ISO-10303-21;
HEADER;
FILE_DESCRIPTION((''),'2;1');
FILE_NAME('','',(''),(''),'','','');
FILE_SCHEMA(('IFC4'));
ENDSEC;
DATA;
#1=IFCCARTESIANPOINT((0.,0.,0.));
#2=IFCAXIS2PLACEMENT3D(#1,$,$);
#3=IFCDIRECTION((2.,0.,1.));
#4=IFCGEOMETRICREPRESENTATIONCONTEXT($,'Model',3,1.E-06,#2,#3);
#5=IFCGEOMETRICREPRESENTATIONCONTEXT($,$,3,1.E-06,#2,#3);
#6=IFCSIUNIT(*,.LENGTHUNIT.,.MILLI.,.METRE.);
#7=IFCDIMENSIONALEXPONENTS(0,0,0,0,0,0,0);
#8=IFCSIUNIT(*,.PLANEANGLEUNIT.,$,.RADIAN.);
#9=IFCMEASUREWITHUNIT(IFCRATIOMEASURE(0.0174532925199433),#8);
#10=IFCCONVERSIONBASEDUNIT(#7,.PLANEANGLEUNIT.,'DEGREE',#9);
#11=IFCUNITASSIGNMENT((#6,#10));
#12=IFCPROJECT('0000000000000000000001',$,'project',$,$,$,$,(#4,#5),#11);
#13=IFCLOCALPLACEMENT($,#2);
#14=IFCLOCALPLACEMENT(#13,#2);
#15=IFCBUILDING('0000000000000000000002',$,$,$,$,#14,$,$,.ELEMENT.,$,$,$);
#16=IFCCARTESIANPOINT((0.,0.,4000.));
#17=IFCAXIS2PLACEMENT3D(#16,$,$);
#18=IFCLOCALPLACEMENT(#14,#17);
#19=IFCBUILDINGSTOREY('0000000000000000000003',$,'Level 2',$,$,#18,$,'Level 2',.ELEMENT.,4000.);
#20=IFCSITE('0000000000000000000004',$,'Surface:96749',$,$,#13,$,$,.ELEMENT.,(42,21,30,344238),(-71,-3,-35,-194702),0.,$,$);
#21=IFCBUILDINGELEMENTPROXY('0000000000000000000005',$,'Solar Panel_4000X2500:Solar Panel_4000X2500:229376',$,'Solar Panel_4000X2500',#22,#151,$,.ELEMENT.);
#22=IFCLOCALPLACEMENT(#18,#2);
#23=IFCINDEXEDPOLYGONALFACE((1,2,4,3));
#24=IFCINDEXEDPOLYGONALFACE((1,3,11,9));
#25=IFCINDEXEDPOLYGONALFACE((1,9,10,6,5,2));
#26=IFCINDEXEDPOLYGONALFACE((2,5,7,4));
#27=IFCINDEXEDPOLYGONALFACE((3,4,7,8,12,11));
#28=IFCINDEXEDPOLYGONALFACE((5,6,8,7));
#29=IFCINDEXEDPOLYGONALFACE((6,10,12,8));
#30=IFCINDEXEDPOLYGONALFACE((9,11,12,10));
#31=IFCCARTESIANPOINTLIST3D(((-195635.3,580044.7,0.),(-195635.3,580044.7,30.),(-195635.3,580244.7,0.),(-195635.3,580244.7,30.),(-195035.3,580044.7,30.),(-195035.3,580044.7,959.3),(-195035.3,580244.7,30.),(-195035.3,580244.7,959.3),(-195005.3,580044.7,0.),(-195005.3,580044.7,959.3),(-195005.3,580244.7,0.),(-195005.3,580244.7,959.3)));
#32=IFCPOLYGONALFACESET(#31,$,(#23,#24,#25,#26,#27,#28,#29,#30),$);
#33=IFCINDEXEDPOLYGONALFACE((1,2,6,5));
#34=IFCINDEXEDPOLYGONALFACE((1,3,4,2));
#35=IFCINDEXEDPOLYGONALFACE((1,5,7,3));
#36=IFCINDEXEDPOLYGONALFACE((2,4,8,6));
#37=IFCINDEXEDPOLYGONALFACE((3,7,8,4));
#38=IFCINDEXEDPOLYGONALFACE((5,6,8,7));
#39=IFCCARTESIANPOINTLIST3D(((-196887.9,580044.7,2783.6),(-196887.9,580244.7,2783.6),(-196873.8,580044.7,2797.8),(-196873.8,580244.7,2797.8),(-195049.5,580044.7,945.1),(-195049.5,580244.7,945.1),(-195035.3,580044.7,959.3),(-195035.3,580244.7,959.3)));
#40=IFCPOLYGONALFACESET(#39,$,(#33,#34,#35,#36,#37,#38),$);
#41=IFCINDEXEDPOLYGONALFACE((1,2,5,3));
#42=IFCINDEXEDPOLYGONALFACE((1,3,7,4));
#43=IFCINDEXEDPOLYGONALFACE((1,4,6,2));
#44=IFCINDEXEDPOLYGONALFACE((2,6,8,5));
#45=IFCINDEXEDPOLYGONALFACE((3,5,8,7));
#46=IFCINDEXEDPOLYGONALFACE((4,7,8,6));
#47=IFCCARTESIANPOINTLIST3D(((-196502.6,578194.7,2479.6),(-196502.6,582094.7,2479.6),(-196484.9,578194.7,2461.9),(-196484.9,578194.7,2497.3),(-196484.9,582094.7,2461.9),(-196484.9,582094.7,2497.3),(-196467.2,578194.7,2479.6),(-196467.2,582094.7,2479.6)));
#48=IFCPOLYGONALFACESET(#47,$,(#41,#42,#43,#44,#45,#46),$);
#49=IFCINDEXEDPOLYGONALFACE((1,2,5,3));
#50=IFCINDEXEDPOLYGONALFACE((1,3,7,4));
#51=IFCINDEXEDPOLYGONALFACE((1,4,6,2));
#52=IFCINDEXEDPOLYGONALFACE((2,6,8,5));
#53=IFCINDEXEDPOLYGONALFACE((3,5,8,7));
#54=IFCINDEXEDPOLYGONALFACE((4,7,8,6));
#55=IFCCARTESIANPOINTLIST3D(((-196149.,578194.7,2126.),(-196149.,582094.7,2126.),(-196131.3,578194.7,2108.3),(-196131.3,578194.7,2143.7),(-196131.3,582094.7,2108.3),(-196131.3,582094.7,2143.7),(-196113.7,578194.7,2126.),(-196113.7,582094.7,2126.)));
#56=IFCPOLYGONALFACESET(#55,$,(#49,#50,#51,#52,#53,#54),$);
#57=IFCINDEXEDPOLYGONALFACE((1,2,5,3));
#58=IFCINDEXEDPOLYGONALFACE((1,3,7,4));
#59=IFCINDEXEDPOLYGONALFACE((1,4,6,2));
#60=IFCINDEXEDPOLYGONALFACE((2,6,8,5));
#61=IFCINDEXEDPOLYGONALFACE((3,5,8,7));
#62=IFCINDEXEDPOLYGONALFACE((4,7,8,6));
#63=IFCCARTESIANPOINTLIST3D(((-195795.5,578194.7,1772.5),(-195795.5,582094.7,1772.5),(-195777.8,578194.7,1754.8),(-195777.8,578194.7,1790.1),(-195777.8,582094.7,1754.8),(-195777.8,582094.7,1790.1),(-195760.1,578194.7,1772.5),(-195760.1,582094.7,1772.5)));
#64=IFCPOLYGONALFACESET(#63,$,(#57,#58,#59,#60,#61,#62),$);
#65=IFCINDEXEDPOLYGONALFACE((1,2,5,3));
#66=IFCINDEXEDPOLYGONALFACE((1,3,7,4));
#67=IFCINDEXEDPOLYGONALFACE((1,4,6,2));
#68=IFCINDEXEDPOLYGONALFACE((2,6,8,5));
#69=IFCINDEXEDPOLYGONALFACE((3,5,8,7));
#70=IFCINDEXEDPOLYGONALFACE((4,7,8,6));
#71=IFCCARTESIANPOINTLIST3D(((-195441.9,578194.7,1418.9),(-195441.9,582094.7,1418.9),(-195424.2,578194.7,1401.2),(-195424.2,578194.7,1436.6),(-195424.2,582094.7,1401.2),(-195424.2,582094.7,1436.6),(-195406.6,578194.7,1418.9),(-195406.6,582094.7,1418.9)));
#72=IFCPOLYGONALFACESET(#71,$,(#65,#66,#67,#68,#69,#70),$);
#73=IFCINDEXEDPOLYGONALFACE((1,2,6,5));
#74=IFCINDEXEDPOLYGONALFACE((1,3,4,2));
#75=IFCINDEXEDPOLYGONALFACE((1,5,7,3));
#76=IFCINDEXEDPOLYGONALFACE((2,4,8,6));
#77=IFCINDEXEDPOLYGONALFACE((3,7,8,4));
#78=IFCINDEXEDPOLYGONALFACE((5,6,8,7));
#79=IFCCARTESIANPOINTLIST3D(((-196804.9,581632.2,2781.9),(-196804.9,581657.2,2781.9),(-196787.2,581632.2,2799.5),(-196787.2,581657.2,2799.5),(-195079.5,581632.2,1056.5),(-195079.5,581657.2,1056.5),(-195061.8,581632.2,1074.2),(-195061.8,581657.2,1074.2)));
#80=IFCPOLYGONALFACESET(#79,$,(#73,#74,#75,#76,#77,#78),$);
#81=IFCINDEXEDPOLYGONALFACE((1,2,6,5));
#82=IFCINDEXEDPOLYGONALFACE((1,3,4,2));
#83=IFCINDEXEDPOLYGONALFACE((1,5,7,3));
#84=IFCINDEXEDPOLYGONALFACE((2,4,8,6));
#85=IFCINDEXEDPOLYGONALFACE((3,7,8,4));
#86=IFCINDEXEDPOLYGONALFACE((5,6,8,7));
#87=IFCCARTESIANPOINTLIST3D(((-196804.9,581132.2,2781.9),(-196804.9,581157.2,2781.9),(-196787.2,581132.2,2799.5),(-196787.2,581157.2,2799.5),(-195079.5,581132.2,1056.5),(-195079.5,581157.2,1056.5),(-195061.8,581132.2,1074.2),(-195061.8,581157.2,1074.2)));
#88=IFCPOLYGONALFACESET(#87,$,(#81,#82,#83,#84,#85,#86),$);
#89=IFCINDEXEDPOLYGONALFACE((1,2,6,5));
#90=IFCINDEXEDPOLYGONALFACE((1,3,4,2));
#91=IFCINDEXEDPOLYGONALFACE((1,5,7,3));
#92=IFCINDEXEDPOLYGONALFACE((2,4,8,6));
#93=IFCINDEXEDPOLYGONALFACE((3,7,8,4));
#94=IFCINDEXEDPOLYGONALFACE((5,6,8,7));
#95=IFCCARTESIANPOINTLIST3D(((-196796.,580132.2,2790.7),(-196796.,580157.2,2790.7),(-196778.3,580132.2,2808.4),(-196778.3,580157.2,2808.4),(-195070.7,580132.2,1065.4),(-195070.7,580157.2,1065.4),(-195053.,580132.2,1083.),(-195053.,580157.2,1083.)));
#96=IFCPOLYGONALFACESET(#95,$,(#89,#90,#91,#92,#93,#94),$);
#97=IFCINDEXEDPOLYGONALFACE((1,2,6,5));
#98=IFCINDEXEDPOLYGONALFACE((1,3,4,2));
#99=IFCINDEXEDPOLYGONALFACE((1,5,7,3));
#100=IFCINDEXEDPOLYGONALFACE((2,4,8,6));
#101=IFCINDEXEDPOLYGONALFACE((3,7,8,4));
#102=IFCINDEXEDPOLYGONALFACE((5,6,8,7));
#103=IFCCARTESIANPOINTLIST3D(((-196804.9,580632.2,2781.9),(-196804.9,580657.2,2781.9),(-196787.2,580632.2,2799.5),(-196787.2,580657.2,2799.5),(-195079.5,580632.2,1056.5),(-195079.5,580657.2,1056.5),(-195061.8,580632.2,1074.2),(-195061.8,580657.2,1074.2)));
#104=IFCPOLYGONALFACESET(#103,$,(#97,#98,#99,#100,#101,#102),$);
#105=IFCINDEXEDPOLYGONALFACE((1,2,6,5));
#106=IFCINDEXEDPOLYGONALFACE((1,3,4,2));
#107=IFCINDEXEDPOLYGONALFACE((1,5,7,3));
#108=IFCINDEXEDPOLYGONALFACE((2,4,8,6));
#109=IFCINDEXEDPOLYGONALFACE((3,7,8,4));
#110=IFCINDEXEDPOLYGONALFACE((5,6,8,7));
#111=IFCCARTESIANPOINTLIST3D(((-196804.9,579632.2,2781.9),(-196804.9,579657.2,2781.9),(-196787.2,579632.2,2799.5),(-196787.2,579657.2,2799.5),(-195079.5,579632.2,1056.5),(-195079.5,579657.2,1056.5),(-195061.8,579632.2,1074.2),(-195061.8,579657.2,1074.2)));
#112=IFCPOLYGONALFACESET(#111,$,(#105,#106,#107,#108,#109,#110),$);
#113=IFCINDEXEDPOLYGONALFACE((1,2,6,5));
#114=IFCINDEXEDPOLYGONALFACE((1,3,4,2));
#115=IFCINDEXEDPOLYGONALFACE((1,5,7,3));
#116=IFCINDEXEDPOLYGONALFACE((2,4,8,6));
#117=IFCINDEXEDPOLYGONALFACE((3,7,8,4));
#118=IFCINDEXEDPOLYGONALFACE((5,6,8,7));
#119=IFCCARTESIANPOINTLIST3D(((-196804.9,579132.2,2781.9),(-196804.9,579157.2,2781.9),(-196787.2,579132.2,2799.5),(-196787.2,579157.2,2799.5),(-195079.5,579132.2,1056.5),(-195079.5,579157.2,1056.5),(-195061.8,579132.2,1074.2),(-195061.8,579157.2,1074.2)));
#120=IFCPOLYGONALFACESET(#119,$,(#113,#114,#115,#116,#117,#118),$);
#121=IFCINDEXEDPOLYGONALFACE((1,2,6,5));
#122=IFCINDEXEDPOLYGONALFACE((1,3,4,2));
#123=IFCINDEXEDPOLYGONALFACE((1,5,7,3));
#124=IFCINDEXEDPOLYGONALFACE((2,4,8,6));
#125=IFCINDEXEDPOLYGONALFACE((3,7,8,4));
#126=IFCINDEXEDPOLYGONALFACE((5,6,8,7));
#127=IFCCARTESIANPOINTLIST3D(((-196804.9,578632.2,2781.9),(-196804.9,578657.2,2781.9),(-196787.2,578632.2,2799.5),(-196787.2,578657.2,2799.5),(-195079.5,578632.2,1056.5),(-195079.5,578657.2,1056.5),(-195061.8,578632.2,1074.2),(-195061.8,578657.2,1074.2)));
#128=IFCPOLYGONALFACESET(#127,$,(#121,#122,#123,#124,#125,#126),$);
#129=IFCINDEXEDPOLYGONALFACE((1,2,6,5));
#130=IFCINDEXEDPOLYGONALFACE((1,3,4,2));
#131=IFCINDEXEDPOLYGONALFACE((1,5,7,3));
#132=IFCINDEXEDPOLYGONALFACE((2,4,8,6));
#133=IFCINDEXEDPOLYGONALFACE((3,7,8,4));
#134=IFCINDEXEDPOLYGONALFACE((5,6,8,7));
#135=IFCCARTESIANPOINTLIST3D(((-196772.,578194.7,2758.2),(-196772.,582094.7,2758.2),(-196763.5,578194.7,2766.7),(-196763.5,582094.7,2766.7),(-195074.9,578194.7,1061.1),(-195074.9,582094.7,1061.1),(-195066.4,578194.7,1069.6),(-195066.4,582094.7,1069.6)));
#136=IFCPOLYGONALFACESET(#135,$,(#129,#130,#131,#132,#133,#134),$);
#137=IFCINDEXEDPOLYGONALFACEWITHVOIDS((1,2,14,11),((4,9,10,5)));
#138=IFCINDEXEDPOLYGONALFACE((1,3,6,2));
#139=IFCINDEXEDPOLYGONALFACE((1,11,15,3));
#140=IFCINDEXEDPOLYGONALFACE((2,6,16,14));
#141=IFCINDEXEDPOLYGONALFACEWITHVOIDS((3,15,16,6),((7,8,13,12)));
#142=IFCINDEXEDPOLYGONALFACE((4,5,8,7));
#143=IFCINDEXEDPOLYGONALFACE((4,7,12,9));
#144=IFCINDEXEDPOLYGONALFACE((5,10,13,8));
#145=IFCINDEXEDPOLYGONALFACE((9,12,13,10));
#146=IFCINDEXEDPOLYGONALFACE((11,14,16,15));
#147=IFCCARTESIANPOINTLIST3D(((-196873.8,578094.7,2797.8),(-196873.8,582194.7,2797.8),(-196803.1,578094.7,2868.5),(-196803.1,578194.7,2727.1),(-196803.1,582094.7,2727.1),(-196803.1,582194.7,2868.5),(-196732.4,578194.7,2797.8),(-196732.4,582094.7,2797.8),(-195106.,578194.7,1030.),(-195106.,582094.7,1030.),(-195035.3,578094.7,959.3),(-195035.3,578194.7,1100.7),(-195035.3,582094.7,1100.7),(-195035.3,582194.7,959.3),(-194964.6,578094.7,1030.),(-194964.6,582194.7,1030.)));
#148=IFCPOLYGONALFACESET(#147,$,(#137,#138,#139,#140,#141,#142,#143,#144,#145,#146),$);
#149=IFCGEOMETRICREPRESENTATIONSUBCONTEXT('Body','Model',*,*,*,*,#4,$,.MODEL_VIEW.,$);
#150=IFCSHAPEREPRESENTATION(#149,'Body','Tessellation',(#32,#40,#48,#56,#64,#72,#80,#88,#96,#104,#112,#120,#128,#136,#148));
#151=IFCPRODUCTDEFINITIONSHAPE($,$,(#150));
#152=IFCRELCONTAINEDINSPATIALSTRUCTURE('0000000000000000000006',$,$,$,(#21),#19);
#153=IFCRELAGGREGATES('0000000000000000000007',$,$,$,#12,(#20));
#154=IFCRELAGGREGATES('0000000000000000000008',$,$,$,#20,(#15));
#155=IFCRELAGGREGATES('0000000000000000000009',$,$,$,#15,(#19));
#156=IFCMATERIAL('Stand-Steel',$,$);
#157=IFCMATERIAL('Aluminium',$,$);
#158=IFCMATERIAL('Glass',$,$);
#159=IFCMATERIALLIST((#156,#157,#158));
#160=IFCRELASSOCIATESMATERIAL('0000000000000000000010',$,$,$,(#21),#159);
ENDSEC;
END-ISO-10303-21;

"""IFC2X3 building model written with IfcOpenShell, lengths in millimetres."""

from ifc_helpers import new_model, entity, si_unit, converted_unit, direction, frame, frame_2d, origin, origin_2d_with_axis, place, context, subcontext, project, spatial, polyline, rectangle, outline, extrude, source, transform, mapped, material, material_list, element, save


model = new_model("IFC2X3")

# Units and contexts
model_context = context("Model", 3, precision=1e-06, world=origin(), true_north=direction((2.0, 0.0, 1.0)))
context_of_model = context(None, 3, precision=1e-06, world=origin(), true_north=direction((2.0, 0.0, 1.0)))
body_context = subcontext(model_context, "Body", "Model", "MODEL_VIEW")
ifc_project = project(units=[si_unit("LENGTHUNIT", "METRE", prefix="MILLI"), converted_unit("PLANEANGLEUNIT", "DEGREE", entity("IfcRatioMeasure", 0.0174532925199433), si_unit("PLANEANGLEUNIT", "RADIAN"), dimensions=[0, 0, 0, 0, 0, 0, 0])], contexts=[model_context, context_of_model])

# Site, building, storey
site_placement = place(None, origin())
site = spatial("IfcSite", under=ifc_project, at=site_placement, Name="Surface:96749", CompositionType="ELEMENT", RefLatitude=(42, 21, 30, 344238), RefLongitude=(-71, -3, -35, -194702), RefElevation=0.0)
building_placement = place(site_placement, origin())
building = spatial("IfcBuilding", under=site, at=building_placement, CompositionType="ELEMENT")
storey_placement = place(building_placement, frame((0.0, 0.0, 4000.0)))
storey = spatial("IfcBuildingStorey", under=building, at=storey_placement, Name="Level 2", LongName="Level 2", CompositionType="ELEMENT", Elevation=4000.0)

# Building element proxy
ifc_material_1 = material(Name="Stand-Steel")
ifc_material_2 = material(Name="Aluminium")
ifc_material_3 = material(Name="Glass")
shared_shape = source(origin(), body_context, "Body", "SweptSolid", [
    extrude(outline(polyline([(-629.5, -220.0), (329.8, -220.0), (329.8, 410.0), (299.8, 410.0), (299.8, -190.0), (-629.5, -190.0), (-629.5, -220.0)])), frame((-190.0, -100.0, 299.8), z_axis=(0.0, 1.0, 0.0), x_axis=(0.0, 0.0, -1.0)), (0.0, 0.0, 1.0), 200.0),
    extrude(rectangle(XDim=20.0, YDim=200.0, at=frame_2d((0.0, 0.0), x_axis=(0.0, 1.0))), frame((-7.1, 0.0, 922.2), z_axis=(-0.707107, 0.0, 0.707107), x_axis=(0.0, 1.0, 0.0)), (0.0, 0.0, 1.0), 2600.0),
    extrude(rectangle(XDim=25.0, YDim=25.0, at=frame_2d((0.0, 0.0), x_axis=(1.0, 0.0))), frame((-1449.6, -1950.0, 2449.6), z_axis=(0.0, 1.0, 0.0), x_axis=(-0.707107, 0.0, -0.707107)), (0.0, 0.0, 1.0), 3900.0),
    extrude(rectangle(XDim=25.0, YDim=25.0, at=origin_2d_with_axis()), frame((-1096.0, -1950.0, 2096.0), z_axis=(0.0, 1.0, 0.0), x_axis=(-0.707107, 0.0, -0.707107)), (0.0, 0.0, 1.0), 3900.0),
    extrude(rectangle(XDim=25.0, YDim=25.0, at=origin_2d_with_axis()), frame((-742.5, -1950.0, 1742.5), z_axis=(0.0, 1.0, 0.0), x_axis=(-0.707107, 0.0, -0.707107)), (0.0, 0.0, 1.0), 3900.0),
    extrude(rectangle(XDim=25.0, YDim=25.0, at=frame_2d((0.0, 0.0), x_axis=(1.0, 0.0))), frame((-388.9, -1950.0, 1388.9), z_axis=(0.0, 1.0, 0.0), x_axis=(-0.707107, 0.0, -0.707107)), (0.0, 0.0, 1.0), 3900.0),
    extrude(rectangle(XDim=25.0, YDim=25.0, at=frame_2d((0.0, 0.0), x_axis=(0.0, 1.0))), frame((-35.4, 1500.0, 1035.4), z_axis=(-0.707107, 0.0, 0.707107), x_axis=(0.0, 1.0, 0.0)), (0.0, 0.0, 1.0), 2440.0),
    extrude(rectangle(XDim=25.0, YDim=25.0, at=frame_2d((0.0, 0.0), x_axis=(0.0, 1.0))), frame((-35.4, 1000.0, 1035.4), z_axis=(-0.707107, 0.0, 0.707107), x_axis=(0.0, 1.0, 0.0)), (0.0, 0.0, 1.0), 2440.0),
    extrude(rectangle(XDim=25.0, YDim=25.0, at=frame_2d((0.0, 0.0), x_axis=(0.0, 1.0))), frame((-26.5, 0.0, 1044.2), z_axis=(-0.707107, 0.0, 0.707107), x_axis=(0.0, -1.0, 0.0)), (0.0, 0.0, 1.0), 2440.0),
    extrude(rectangle(XDim=25.0, YDim=25.0, at=frame_2d((0.0, 0.0), x_axis=(0.0, 1.0))), frame((-35.4, 500.0, 1035.4), z_axis=(-0.707107, 0.0, 0.707107), x_axis=(0.0, 1.0, 0.0)), (0.0, 0.0, 1.0), 2440.0),
    extrude(rectangle(XDim=25.0, YDim=25.0, at=frame_2d((0.0, 0.0), x_axis=(0.0, 1.0))), frame((-35.4, -500.0, 1035.4), z_axis=(-0.707107, 0.0, 0.707107), x_axis=(0.0, 1.0, 0.0)), (0.0, 0.0, 1.0), 2440.0),
    extrude(rectangle(XDim=25.0, YDim=25.0, at=frame_2d((0.0, 0.0), x_axis=(0.0, 1.0))), frame((-35.4, -1000.0, 1035.4), z_axis=(-0.707107, 0.0, 0.707107), x_axis=(0.0, 1.0, 0.0)), (0.0, 0.0, 1.0), 2440.0),
    extrude(rectangle(XDim=25.0, YDim=25.0, at=frame_2d((0.0, 0.0), x_axis=(0.0, 1.0))), frame((-35.4, -1500.0, 1035.4), z_axis=(-0.707107, 0.0, 0.707107), x_axis=(0.0, 1.0, 0.0)), (0.0, 0.0, 1.0), 2440.0),
    extrude(rectangle(XDim=2400.0, YDim=12.0, at=frame_2d((0.0, 0.0), x_axis=(1.0, 0.0))), frame((-883.9, -1950.0, 1883.9), z_axis=(0.0, 1.0, 0.0), x_axis=(0.707107, 0.0, -0.707107)), (0.0, 0.0, 1.0), 3900.0),
    extrude(outline(polyline([(-2050.0, -1300.0), (2050.0, -1300.0), (2050.0, 1300.0), (-2050.0, 1300.0), (-2050.0, -1300.0)]), holes=[polyline([(1950.0, -1200.0), (-1950.0, -1200.0), (-1950.0, 1200.0), (1950.0, 1200.0), (1950.0, -1200.0)])]), frame((-919.2, 0.0, 1848.5), z_axis=(0.707107, 0.0, 0.707107), x_axis=(0.0, 1.0, 0.0)), (0.0, 0.0, 1.0), 100.0),
])
ifc_material_list_1 = material_list([ifc_material_1, ifc_material_2, ifc_material_3])
proxy_1_placement = place(storey_placement, frame((-195035.3, 580144.7, 30.0)))
element("IfcBuildingElementProxy", 1, at=proxy_1_placement, inside=storey, material=ifc_material_list_1, Name="Solar Panel_4000X2500:Solar Panel_4000X2500:229376", ObjectType="Solar Panel_4000X2500", CompositionType="ELEMENT", context=body_context, shape_type="MappedRepresentation", body=[
    mapped(shared_shape, transform((0.0, 0.0, 0.0), scale=1.0)),
])

save(model, "model.ifc")
